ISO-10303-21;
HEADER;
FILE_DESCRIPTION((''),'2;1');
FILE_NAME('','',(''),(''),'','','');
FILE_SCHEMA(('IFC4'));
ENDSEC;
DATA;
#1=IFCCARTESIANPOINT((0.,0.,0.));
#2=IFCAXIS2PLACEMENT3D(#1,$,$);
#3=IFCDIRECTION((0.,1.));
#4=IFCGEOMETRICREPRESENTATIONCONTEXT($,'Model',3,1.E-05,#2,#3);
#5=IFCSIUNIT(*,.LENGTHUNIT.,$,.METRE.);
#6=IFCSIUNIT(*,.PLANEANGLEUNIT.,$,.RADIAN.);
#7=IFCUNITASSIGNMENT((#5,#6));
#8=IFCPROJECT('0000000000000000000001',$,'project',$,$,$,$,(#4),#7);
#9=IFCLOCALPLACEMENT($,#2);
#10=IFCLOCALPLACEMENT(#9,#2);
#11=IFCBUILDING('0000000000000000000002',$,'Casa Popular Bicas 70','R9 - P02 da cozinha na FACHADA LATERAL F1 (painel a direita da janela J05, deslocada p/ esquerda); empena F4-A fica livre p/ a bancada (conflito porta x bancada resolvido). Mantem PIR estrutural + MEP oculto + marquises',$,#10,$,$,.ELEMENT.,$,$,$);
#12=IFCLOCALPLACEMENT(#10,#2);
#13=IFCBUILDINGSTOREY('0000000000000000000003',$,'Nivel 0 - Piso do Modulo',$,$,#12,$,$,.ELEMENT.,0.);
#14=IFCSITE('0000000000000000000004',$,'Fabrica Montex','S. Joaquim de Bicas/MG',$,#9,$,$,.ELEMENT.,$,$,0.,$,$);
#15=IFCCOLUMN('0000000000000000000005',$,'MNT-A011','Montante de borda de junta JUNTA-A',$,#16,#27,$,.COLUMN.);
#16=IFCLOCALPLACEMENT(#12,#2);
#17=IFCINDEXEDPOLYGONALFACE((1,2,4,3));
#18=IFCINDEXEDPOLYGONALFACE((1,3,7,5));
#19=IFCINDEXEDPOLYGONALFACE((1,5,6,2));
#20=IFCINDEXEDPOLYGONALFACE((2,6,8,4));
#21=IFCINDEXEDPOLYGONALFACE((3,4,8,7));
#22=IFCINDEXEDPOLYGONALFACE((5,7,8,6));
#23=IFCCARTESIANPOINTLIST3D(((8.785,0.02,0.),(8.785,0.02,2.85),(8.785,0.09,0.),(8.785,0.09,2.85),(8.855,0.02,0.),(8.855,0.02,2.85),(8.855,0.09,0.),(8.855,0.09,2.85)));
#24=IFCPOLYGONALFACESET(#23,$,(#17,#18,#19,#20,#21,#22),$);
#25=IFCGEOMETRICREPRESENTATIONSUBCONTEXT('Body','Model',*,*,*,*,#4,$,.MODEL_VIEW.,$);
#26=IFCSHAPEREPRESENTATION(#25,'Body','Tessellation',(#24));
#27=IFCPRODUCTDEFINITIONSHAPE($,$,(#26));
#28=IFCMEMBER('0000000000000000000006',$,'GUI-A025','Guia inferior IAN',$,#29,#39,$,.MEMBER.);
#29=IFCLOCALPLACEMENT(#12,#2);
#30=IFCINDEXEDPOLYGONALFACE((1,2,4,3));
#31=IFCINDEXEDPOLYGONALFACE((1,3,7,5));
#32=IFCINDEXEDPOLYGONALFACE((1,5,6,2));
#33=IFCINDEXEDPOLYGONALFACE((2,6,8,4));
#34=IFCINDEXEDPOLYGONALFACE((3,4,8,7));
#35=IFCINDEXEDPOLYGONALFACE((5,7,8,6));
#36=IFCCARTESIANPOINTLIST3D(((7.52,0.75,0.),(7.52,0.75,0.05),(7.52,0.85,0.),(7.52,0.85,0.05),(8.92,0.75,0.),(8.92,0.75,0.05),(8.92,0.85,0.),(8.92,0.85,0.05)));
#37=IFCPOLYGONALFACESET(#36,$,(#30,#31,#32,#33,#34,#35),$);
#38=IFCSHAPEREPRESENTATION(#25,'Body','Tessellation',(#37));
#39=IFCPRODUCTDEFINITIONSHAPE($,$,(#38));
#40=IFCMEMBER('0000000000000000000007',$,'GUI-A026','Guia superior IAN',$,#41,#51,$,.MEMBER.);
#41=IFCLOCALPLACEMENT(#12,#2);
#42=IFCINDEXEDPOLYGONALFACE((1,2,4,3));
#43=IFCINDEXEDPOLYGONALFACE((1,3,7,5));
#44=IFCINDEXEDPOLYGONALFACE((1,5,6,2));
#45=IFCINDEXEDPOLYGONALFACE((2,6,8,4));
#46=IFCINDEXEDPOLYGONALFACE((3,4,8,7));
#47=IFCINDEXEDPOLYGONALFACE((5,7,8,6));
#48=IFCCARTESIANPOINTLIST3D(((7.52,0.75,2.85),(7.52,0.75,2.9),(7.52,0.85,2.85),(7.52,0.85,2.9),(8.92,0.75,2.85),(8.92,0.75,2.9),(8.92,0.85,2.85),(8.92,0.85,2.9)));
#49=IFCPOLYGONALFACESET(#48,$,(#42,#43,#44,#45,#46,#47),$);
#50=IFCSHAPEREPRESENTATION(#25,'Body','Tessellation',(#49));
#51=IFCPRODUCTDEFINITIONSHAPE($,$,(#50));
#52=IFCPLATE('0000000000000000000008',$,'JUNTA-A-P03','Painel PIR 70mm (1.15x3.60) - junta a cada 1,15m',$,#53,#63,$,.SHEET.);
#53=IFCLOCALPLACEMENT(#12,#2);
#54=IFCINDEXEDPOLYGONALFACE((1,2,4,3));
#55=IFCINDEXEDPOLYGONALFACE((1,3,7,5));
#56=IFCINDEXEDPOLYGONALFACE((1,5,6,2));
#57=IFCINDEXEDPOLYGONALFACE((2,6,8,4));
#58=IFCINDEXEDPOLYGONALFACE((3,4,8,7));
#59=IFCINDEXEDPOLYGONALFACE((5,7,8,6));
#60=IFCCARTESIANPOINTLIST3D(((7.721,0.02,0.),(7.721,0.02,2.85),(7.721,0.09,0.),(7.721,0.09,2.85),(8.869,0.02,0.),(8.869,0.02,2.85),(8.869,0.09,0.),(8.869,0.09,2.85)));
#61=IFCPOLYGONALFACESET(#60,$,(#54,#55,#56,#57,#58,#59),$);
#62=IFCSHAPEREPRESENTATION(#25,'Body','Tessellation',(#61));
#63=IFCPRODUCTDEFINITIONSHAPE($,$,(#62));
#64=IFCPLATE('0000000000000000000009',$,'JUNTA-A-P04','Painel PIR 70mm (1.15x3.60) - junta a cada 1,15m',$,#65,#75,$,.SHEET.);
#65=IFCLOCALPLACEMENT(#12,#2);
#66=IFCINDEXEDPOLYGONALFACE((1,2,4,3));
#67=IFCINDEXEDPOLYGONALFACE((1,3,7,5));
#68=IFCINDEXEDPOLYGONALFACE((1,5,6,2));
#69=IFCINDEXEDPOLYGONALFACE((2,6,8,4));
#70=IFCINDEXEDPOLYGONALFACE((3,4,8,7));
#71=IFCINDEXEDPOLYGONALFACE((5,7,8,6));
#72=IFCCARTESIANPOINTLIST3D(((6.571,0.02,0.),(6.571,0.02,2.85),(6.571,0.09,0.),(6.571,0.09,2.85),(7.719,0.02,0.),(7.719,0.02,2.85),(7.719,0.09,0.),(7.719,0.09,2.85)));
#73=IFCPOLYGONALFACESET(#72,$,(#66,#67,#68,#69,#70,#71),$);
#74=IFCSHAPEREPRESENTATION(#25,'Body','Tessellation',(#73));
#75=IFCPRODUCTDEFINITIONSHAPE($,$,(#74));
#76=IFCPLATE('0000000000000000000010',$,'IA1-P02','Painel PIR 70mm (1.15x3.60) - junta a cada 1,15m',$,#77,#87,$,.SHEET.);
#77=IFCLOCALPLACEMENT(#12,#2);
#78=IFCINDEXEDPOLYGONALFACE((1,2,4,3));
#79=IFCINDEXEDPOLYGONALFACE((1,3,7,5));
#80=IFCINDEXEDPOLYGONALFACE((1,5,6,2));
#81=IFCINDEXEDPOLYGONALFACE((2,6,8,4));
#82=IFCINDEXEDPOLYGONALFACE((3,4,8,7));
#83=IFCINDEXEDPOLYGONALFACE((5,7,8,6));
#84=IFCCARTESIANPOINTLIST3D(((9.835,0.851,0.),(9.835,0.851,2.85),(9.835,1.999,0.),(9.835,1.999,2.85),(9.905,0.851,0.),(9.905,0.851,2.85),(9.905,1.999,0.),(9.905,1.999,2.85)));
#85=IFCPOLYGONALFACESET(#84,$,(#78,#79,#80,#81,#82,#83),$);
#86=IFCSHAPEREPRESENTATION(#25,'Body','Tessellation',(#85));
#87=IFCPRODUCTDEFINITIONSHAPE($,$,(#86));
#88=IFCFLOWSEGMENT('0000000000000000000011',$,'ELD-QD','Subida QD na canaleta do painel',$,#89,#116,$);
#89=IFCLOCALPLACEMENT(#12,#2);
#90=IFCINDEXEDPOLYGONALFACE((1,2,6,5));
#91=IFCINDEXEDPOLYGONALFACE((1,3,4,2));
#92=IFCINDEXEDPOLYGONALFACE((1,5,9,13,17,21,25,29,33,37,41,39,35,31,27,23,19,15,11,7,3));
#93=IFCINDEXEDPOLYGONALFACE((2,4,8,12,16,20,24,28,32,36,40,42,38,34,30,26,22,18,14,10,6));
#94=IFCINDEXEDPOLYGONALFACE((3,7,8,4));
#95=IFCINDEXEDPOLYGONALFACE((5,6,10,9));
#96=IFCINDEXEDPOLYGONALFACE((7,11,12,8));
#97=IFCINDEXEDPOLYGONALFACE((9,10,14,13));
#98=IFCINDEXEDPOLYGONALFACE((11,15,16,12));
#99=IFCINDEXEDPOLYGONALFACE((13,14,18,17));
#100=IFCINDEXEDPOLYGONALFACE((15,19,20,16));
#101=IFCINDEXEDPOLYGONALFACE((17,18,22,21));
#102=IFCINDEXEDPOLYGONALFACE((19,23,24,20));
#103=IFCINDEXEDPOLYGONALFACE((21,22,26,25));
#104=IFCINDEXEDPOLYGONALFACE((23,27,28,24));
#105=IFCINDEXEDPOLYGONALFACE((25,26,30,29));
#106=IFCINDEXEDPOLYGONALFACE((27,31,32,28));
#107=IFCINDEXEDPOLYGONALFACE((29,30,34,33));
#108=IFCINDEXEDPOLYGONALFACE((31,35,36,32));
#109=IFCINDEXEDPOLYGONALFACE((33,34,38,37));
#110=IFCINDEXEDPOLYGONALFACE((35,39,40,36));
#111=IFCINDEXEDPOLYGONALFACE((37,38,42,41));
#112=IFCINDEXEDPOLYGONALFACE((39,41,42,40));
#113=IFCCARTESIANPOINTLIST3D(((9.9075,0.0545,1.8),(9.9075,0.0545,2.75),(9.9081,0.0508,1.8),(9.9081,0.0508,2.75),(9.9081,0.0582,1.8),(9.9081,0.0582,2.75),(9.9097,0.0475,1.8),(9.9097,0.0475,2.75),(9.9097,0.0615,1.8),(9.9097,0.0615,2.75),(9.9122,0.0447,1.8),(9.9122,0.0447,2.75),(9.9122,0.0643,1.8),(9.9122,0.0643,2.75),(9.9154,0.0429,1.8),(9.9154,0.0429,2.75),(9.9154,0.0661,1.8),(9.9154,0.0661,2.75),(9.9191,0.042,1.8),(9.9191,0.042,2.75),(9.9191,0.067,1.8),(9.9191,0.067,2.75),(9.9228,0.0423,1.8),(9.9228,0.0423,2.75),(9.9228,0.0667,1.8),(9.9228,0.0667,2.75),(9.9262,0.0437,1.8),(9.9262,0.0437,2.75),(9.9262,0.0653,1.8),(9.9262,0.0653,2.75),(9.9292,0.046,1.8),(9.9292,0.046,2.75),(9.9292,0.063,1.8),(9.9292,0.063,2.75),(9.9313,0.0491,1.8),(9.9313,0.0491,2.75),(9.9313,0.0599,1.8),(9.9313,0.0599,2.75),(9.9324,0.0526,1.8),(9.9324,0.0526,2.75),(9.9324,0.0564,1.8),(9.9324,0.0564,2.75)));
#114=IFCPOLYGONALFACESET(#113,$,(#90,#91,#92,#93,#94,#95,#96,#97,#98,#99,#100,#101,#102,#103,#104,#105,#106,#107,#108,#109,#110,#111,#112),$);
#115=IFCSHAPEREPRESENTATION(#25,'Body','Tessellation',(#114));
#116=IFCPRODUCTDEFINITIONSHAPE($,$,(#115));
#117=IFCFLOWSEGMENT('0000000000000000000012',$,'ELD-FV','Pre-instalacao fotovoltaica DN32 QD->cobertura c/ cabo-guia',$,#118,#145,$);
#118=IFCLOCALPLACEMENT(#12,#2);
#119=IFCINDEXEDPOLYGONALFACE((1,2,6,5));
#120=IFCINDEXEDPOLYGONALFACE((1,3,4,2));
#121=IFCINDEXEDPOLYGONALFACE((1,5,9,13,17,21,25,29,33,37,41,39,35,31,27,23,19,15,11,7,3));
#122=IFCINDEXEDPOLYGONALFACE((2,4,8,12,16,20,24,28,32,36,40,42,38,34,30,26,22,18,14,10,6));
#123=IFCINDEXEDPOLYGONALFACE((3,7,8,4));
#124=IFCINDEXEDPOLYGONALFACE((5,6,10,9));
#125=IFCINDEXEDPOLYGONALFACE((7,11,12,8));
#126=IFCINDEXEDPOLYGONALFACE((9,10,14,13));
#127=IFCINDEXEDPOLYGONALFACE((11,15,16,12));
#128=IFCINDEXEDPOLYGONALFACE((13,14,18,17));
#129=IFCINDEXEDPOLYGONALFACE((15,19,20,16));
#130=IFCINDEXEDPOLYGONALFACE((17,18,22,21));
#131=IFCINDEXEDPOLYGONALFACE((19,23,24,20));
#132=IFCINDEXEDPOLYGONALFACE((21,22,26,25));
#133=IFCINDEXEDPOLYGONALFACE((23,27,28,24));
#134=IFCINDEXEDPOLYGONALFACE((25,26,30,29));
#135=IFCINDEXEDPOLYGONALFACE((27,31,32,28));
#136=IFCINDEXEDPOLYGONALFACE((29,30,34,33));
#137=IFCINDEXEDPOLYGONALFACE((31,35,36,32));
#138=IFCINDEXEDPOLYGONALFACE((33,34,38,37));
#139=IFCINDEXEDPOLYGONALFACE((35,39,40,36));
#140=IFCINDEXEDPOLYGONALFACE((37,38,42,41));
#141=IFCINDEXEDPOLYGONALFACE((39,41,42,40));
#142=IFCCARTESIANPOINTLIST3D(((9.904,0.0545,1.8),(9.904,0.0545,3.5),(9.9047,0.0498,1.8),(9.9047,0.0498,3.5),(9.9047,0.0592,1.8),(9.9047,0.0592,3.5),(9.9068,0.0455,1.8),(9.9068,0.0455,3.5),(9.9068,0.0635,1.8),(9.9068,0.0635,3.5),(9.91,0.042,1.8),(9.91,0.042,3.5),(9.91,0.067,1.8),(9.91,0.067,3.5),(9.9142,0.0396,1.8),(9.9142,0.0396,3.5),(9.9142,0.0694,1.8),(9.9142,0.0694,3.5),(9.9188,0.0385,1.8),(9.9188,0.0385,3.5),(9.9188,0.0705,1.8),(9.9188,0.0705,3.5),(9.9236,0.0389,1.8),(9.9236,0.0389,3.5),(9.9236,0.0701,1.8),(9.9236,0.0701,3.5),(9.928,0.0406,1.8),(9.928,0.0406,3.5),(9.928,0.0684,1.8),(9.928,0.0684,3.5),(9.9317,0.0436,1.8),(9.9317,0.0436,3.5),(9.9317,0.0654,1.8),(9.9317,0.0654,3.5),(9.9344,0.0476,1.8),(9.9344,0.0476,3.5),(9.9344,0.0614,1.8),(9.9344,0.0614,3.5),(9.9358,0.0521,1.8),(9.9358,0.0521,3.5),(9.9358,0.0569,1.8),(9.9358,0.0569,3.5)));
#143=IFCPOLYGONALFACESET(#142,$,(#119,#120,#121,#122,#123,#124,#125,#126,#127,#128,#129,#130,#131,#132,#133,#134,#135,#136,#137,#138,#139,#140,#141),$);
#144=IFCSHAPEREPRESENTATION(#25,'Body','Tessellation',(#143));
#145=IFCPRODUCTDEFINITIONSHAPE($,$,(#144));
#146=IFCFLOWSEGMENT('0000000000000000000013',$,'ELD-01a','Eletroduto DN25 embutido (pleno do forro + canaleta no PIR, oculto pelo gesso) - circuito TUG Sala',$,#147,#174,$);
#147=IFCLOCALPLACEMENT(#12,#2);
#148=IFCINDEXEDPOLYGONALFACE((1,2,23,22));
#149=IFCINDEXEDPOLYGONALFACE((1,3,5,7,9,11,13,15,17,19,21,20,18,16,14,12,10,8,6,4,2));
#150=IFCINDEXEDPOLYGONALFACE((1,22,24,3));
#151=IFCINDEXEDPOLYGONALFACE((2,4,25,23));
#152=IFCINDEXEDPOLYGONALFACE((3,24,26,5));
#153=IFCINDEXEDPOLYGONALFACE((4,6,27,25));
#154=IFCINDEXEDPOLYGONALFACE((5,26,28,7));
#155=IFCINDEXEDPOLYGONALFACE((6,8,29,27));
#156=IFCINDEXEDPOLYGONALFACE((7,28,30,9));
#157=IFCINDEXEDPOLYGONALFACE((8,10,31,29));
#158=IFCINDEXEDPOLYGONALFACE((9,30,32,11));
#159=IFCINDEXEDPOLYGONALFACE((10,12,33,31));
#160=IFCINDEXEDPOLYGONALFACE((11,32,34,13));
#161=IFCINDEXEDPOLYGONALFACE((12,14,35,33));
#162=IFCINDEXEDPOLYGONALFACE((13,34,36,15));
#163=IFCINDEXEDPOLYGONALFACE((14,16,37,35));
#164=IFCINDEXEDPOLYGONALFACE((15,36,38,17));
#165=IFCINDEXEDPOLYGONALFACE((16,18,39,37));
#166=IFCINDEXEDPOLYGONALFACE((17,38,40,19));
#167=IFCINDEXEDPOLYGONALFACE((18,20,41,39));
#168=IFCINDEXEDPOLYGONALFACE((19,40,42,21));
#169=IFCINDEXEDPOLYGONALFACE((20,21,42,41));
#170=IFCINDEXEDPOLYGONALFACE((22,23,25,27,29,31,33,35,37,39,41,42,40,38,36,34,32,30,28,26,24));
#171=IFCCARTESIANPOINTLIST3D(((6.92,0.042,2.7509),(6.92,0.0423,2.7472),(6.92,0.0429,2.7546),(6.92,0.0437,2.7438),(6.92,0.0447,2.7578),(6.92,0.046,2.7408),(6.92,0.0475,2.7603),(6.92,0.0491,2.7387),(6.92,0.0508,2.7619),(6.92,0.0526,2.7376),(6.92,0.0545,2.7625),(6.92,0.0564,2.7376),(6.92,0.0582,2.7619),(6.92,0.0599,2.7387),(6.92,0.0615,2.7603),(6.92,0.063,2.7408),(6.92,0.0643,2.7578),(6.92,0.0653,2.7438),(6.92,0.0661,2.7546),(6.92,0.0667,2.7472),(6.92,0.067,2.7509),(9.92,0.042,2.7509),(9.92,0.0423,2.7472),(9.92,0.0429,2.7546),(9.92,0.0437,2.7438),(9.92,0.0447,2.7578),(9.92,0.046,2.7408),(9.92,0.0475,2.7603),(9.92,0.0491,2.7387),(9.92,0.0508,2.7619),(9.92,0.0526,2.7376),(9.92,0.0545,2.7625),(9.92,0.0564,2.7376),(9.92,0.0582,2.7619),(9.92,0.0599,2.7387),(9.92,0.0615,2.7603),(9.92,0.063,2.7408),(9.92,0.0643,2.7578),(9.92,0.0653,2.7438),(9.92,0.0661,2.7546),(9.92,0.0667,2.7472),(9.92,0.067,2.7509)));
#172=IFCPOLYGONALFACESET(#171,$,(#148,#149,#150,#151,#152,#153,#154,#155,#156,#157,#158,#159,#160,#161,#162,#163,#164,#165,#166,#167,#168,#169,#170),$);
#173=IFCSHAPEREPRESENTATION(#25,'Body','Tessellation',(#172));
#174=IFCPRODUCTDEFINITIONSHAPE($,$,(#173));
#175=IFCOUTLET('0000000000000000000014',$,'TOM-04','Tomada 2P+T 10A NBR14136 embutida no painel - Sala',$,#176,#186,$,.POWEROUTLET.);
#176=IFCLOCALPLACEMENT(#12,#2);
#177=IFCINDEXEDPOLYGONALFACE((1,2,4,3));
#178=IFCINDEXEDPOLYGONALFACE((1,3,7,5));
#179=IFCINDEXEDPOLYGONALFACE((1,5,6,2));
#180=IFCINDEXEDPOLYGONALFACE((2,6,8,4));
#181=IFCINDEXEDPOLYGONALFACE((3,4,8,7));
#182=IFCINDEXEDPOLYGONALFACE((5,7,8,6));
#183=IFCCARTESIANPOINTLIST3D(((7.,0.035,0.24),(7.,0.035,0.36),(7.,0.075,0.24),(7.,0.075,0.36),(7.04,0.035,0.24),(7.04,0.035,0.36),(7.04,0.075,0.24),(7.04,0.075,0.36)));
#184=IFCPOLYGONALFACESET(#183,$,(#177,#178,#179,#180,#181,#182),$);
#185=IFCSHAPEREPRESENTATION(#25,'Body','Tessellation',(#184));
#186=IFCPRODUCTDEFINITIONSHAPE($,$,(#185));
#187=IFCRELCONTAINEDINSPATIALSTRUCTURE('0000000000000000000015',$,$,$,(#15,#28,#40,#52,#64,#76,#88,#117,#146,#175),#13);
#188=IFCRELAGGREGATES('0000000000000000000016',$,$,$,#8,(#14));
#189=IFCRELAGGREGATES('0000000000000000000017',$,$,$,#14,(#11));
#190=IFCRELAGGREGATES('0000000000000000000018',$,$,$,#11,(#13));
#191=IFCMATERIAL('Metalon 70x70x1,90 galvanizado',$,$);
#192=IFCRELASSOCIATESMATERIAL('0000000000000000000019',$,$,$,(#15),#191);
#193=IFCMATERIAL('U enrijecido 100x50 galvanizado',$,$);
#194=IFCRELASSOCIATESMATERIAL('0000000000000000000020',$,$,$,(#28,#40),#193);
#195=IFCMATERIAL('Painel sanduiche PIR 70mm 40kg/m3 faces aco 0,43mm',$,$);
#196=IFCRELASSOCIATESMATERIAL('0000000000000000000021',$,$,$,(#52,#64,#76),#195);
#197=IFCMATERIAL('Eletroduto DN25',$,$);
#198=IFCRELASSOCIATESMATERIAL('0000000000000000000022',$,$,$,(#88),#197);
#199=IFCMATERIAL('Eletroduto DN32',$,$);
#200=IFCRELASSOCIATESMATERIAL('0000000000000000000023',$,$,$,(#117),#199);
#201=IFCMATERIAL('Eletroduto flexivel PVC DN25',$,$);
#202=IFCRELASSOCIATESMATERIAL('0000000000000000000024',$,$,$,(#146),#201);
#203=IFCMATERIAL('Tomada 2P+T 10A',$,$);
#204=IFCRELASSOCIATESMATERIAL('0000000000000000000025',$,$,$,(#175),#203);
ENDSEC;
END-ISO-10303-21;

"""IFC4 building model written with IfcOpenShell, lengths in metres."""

from ifc_helpers import new_model, si_unit, direction, frame, frame_2d, origin, origin_2d, place, context, subcontext, project, spatial, rectangle, circle, extrude, material, element, save


model = new_model("IFC4")

# Units and contexts
model_context = context("Model", 3, precision=1e-05, world=origin(), true_north=direction((0.0, 1.0)))
body_context = subcontext(model_context, "Body", "Model", "MODEL_VIEW")
ifc_project = project(units=[si_unit("LENGTHUNIT", "METRE"), si_unit("PLANEANGLEUNIT", "RADIAN")], contexts=[model_context])

# Site, building, storey
site_placement = place(None, origin())
site = spatial("IfcSite", under=ifc_project, at=site_placement, Name="Fabrica Montex", Description="S. Joaquim de Bicas/MG", CompositionType="ELEMENT", RefElevation=0.0)
building_placement = place(site_placement, origin())
building = spatial("IfcBuilding", under=site, at=building_placement, Name="Casa Popular Bicas 70", Description="R9 - P02 da cozinha na FACHADA LATERAL F1 (painel a direita da janela J05, deslocada p/ esquerda); empena F4-A fica livre p/ a bancada (conflito porta x bancada resolvido). Mantem PIR estrutural + MEP oculto + marquises", CompositionType="ELEMENT")
storey_placement = place(building_placement, origin())
storey = spatial("IfcBuildingStorey", under=building, at=storey_placement, Name="Nivel 0 - Piso do Modulo", CompositionType="ELEMENT", Elevation=0.0)

# Column
ifc_material_1 = material(Name="Metalon 70x70x1,90 galvanizado")
column_placement = place(None, frame((8.82, 0.055, 0.0), z_axis=(0.0, 0.0, 1.0), x_axis=(-1.0, 0.0, 0.0)))
element("IfcColumn", 1, at=column_placement, inside=storey, material=ifc_material_1, Name="MNT-A011", Description="Montante de borda de junta JUNTA-A", PredefinedType="COLUMN", context=body_context, shape_type="SweptSolid", body=[
    extrude(rectangle(XDim=0.07, YDim=0.07, at=origin_2d()), origin(), (0.0, 0.0, 1.0), 2.85),
])

# Members
ifc_material_2 = material(Name="U enrijecido 100x50 galvanizado")
for number, where, z_axis, x_axis, name, description in (
    (2, (8.92, 0.8, 0.025), (-1.0, 0.0, 0.0), (0.0, 0.0, 1.0), "GUI-A025", "Guia inferior IAN"),
    (3, (8.92, 0.8, 2.875), (-1.0, 0.0, 0.0), (0.0, 0.0, 1.0), "GUI-A026", "Guia superior IAN"),
):
    element("IfcMember", number, at=place(None, frame(where, z_axis=z_axis, x_axis=x_axis)), inside=storey, material=ifc_material_2, Name=name, Description=description, PredefinedType="MEMBER", context=body_context, shape_type="SweptSolid", body=[
        extrude(rectangle(XDim=0.05, YDim=0.1, at=origin_2d()), origin(), (0.0, 0.0, 1.0), 1.4),
    ])

# Plates
ifc_material_3 = material(Name="Painel sanduiche PIR 70mm 40kg/m3 faces aco 0,43mm")
for number, where, z_axis, x_axis, name in (
    (4, (8.869, 0.055, 0.0), (0.0, 0.0, 1.0), (-1.0, 0.0, 0.0), "JUNTA-A-P03"),
    (5, (7.719, 0.055, 0.0), (0.0, 0.0, 1.0), (-1.0, 0.0, 0.0), "JUNTA-A-P04"),
    (6, (9.87, 1.999, 0.0), (0.0, 0.0, 1.0), (0.0, -1.0, 0.0), "IA1-P02"),
):
    element("IfcPlate", number, at=place(None, frame(where, z_axis=z_axis, x_axis=x_axis)), inside=storey, material=ifc_material_3, Name=name, Description="Painel PIR 70mm (1.15x3.60) - junta a cada 1,15m", PredefinedType="SHEET", context=body_context, shape_type="SweptSolid", body=[
        extrude(rectangle(XDim=1.148, YDim=0.07, at=frame_2d((0.574, 0.0))), origin(), (0.0, 0.0, 1.0), 2.85),
    ])

# Flow segments
ifc_material_4 = material(Name="Eletroduto DN25")
flow_segment_1_placement = place(None, frame((9.92, 0.0545, 1.8), z_axis=(0.0, 0.0, 1.0), x_axis=(-1.0, 0.0, 0.0)))
element("IfcFlowSegment", 7, at=flow_segment_1_placement, inside=storey, material=ifc_material_4, Name="ELD-QD", Description="Subida QD na canaleta do painel", context=body_context, shape_type="SweptSolid", body=[
    extrude(circle(Radius=0.0125, at=origin_2d()), origin(), (0.0, 0.0, 1.0), 0.95),
])
ifc_material_5 = material(Name="Eletroduto DN32")
flow_segment_2_placement = place(None, frame((9.92, 0.0545, 1.8), z_axis=(0.0, 0.0, 1.0), x_axis=(-1.0, 0.0, 0.0)))
element("IfcFlowSegment", 8, at=flow_segment_2_placement, inside=storey, material=ifc_material_5, Name="ELD-FV", Description="Pre-instalacao fotovoltaica DN32 QD->cobertura c/ cabo-guia", context=body_context, shape_type="SweptSolid", body=[
    extrude(circle(Radius=0.016, at=origin_2d()), origin(), (0.0, 0.0, 1.0), 1.7),
])
ifc_material_6 = material(Name="Eletroduto flexivel PVC DN25")
flow_segment_3_placement = place(None, frame((9.92, 0.0545, 2.75), z_axis=(-1.0, 0.0, 0.0), x_axis=(0.0, 0.0, 1.0)))
element("IfcFlowSegment", 9, at=flow_segment_3_placement, inside=storey, material=ifc_material_6, Name="ELD-01a", Description="Eletroduto DN25 embutido (pleno do forro + canaleta no PIR, oculto pelo gesso) - circuito TUG Sala", context=body_context, shape_type="SweptSolid", body=[
    extrude(circle(Radius=0.0125, at=origin_2d()), origin(), (0.0, 0.0, 1.0), 3.0),
])

# Outlet
ifc_material_7 = material(Name="Tomada 2P+T 10A")
outlet_1_placement = place(None, frame((7.04, 0.075, 0.24), z_axis=(0.0, 0.0, 1.0), x_axis=(-1.0, 0.0, 0.0)))
element("IfcOutlet", 10, at=outlet_1_placement, inside=storey, material=ifc_material_7, Name="TOM-04", Description="Tomada 2P+T 10A NBR14136 embutida no painel - Sala", PredefinedType="POWEROUTLET", context=body_context, shape_type="SweptSolid", body=[
    extrude(rectangle(XDim=0.04, YDim=0.04, at=frame_2d((0.02, 0.02))), origin(), (0.0, 0.0, 1.0), 0.12),
])

save(model, "model.ifc")
